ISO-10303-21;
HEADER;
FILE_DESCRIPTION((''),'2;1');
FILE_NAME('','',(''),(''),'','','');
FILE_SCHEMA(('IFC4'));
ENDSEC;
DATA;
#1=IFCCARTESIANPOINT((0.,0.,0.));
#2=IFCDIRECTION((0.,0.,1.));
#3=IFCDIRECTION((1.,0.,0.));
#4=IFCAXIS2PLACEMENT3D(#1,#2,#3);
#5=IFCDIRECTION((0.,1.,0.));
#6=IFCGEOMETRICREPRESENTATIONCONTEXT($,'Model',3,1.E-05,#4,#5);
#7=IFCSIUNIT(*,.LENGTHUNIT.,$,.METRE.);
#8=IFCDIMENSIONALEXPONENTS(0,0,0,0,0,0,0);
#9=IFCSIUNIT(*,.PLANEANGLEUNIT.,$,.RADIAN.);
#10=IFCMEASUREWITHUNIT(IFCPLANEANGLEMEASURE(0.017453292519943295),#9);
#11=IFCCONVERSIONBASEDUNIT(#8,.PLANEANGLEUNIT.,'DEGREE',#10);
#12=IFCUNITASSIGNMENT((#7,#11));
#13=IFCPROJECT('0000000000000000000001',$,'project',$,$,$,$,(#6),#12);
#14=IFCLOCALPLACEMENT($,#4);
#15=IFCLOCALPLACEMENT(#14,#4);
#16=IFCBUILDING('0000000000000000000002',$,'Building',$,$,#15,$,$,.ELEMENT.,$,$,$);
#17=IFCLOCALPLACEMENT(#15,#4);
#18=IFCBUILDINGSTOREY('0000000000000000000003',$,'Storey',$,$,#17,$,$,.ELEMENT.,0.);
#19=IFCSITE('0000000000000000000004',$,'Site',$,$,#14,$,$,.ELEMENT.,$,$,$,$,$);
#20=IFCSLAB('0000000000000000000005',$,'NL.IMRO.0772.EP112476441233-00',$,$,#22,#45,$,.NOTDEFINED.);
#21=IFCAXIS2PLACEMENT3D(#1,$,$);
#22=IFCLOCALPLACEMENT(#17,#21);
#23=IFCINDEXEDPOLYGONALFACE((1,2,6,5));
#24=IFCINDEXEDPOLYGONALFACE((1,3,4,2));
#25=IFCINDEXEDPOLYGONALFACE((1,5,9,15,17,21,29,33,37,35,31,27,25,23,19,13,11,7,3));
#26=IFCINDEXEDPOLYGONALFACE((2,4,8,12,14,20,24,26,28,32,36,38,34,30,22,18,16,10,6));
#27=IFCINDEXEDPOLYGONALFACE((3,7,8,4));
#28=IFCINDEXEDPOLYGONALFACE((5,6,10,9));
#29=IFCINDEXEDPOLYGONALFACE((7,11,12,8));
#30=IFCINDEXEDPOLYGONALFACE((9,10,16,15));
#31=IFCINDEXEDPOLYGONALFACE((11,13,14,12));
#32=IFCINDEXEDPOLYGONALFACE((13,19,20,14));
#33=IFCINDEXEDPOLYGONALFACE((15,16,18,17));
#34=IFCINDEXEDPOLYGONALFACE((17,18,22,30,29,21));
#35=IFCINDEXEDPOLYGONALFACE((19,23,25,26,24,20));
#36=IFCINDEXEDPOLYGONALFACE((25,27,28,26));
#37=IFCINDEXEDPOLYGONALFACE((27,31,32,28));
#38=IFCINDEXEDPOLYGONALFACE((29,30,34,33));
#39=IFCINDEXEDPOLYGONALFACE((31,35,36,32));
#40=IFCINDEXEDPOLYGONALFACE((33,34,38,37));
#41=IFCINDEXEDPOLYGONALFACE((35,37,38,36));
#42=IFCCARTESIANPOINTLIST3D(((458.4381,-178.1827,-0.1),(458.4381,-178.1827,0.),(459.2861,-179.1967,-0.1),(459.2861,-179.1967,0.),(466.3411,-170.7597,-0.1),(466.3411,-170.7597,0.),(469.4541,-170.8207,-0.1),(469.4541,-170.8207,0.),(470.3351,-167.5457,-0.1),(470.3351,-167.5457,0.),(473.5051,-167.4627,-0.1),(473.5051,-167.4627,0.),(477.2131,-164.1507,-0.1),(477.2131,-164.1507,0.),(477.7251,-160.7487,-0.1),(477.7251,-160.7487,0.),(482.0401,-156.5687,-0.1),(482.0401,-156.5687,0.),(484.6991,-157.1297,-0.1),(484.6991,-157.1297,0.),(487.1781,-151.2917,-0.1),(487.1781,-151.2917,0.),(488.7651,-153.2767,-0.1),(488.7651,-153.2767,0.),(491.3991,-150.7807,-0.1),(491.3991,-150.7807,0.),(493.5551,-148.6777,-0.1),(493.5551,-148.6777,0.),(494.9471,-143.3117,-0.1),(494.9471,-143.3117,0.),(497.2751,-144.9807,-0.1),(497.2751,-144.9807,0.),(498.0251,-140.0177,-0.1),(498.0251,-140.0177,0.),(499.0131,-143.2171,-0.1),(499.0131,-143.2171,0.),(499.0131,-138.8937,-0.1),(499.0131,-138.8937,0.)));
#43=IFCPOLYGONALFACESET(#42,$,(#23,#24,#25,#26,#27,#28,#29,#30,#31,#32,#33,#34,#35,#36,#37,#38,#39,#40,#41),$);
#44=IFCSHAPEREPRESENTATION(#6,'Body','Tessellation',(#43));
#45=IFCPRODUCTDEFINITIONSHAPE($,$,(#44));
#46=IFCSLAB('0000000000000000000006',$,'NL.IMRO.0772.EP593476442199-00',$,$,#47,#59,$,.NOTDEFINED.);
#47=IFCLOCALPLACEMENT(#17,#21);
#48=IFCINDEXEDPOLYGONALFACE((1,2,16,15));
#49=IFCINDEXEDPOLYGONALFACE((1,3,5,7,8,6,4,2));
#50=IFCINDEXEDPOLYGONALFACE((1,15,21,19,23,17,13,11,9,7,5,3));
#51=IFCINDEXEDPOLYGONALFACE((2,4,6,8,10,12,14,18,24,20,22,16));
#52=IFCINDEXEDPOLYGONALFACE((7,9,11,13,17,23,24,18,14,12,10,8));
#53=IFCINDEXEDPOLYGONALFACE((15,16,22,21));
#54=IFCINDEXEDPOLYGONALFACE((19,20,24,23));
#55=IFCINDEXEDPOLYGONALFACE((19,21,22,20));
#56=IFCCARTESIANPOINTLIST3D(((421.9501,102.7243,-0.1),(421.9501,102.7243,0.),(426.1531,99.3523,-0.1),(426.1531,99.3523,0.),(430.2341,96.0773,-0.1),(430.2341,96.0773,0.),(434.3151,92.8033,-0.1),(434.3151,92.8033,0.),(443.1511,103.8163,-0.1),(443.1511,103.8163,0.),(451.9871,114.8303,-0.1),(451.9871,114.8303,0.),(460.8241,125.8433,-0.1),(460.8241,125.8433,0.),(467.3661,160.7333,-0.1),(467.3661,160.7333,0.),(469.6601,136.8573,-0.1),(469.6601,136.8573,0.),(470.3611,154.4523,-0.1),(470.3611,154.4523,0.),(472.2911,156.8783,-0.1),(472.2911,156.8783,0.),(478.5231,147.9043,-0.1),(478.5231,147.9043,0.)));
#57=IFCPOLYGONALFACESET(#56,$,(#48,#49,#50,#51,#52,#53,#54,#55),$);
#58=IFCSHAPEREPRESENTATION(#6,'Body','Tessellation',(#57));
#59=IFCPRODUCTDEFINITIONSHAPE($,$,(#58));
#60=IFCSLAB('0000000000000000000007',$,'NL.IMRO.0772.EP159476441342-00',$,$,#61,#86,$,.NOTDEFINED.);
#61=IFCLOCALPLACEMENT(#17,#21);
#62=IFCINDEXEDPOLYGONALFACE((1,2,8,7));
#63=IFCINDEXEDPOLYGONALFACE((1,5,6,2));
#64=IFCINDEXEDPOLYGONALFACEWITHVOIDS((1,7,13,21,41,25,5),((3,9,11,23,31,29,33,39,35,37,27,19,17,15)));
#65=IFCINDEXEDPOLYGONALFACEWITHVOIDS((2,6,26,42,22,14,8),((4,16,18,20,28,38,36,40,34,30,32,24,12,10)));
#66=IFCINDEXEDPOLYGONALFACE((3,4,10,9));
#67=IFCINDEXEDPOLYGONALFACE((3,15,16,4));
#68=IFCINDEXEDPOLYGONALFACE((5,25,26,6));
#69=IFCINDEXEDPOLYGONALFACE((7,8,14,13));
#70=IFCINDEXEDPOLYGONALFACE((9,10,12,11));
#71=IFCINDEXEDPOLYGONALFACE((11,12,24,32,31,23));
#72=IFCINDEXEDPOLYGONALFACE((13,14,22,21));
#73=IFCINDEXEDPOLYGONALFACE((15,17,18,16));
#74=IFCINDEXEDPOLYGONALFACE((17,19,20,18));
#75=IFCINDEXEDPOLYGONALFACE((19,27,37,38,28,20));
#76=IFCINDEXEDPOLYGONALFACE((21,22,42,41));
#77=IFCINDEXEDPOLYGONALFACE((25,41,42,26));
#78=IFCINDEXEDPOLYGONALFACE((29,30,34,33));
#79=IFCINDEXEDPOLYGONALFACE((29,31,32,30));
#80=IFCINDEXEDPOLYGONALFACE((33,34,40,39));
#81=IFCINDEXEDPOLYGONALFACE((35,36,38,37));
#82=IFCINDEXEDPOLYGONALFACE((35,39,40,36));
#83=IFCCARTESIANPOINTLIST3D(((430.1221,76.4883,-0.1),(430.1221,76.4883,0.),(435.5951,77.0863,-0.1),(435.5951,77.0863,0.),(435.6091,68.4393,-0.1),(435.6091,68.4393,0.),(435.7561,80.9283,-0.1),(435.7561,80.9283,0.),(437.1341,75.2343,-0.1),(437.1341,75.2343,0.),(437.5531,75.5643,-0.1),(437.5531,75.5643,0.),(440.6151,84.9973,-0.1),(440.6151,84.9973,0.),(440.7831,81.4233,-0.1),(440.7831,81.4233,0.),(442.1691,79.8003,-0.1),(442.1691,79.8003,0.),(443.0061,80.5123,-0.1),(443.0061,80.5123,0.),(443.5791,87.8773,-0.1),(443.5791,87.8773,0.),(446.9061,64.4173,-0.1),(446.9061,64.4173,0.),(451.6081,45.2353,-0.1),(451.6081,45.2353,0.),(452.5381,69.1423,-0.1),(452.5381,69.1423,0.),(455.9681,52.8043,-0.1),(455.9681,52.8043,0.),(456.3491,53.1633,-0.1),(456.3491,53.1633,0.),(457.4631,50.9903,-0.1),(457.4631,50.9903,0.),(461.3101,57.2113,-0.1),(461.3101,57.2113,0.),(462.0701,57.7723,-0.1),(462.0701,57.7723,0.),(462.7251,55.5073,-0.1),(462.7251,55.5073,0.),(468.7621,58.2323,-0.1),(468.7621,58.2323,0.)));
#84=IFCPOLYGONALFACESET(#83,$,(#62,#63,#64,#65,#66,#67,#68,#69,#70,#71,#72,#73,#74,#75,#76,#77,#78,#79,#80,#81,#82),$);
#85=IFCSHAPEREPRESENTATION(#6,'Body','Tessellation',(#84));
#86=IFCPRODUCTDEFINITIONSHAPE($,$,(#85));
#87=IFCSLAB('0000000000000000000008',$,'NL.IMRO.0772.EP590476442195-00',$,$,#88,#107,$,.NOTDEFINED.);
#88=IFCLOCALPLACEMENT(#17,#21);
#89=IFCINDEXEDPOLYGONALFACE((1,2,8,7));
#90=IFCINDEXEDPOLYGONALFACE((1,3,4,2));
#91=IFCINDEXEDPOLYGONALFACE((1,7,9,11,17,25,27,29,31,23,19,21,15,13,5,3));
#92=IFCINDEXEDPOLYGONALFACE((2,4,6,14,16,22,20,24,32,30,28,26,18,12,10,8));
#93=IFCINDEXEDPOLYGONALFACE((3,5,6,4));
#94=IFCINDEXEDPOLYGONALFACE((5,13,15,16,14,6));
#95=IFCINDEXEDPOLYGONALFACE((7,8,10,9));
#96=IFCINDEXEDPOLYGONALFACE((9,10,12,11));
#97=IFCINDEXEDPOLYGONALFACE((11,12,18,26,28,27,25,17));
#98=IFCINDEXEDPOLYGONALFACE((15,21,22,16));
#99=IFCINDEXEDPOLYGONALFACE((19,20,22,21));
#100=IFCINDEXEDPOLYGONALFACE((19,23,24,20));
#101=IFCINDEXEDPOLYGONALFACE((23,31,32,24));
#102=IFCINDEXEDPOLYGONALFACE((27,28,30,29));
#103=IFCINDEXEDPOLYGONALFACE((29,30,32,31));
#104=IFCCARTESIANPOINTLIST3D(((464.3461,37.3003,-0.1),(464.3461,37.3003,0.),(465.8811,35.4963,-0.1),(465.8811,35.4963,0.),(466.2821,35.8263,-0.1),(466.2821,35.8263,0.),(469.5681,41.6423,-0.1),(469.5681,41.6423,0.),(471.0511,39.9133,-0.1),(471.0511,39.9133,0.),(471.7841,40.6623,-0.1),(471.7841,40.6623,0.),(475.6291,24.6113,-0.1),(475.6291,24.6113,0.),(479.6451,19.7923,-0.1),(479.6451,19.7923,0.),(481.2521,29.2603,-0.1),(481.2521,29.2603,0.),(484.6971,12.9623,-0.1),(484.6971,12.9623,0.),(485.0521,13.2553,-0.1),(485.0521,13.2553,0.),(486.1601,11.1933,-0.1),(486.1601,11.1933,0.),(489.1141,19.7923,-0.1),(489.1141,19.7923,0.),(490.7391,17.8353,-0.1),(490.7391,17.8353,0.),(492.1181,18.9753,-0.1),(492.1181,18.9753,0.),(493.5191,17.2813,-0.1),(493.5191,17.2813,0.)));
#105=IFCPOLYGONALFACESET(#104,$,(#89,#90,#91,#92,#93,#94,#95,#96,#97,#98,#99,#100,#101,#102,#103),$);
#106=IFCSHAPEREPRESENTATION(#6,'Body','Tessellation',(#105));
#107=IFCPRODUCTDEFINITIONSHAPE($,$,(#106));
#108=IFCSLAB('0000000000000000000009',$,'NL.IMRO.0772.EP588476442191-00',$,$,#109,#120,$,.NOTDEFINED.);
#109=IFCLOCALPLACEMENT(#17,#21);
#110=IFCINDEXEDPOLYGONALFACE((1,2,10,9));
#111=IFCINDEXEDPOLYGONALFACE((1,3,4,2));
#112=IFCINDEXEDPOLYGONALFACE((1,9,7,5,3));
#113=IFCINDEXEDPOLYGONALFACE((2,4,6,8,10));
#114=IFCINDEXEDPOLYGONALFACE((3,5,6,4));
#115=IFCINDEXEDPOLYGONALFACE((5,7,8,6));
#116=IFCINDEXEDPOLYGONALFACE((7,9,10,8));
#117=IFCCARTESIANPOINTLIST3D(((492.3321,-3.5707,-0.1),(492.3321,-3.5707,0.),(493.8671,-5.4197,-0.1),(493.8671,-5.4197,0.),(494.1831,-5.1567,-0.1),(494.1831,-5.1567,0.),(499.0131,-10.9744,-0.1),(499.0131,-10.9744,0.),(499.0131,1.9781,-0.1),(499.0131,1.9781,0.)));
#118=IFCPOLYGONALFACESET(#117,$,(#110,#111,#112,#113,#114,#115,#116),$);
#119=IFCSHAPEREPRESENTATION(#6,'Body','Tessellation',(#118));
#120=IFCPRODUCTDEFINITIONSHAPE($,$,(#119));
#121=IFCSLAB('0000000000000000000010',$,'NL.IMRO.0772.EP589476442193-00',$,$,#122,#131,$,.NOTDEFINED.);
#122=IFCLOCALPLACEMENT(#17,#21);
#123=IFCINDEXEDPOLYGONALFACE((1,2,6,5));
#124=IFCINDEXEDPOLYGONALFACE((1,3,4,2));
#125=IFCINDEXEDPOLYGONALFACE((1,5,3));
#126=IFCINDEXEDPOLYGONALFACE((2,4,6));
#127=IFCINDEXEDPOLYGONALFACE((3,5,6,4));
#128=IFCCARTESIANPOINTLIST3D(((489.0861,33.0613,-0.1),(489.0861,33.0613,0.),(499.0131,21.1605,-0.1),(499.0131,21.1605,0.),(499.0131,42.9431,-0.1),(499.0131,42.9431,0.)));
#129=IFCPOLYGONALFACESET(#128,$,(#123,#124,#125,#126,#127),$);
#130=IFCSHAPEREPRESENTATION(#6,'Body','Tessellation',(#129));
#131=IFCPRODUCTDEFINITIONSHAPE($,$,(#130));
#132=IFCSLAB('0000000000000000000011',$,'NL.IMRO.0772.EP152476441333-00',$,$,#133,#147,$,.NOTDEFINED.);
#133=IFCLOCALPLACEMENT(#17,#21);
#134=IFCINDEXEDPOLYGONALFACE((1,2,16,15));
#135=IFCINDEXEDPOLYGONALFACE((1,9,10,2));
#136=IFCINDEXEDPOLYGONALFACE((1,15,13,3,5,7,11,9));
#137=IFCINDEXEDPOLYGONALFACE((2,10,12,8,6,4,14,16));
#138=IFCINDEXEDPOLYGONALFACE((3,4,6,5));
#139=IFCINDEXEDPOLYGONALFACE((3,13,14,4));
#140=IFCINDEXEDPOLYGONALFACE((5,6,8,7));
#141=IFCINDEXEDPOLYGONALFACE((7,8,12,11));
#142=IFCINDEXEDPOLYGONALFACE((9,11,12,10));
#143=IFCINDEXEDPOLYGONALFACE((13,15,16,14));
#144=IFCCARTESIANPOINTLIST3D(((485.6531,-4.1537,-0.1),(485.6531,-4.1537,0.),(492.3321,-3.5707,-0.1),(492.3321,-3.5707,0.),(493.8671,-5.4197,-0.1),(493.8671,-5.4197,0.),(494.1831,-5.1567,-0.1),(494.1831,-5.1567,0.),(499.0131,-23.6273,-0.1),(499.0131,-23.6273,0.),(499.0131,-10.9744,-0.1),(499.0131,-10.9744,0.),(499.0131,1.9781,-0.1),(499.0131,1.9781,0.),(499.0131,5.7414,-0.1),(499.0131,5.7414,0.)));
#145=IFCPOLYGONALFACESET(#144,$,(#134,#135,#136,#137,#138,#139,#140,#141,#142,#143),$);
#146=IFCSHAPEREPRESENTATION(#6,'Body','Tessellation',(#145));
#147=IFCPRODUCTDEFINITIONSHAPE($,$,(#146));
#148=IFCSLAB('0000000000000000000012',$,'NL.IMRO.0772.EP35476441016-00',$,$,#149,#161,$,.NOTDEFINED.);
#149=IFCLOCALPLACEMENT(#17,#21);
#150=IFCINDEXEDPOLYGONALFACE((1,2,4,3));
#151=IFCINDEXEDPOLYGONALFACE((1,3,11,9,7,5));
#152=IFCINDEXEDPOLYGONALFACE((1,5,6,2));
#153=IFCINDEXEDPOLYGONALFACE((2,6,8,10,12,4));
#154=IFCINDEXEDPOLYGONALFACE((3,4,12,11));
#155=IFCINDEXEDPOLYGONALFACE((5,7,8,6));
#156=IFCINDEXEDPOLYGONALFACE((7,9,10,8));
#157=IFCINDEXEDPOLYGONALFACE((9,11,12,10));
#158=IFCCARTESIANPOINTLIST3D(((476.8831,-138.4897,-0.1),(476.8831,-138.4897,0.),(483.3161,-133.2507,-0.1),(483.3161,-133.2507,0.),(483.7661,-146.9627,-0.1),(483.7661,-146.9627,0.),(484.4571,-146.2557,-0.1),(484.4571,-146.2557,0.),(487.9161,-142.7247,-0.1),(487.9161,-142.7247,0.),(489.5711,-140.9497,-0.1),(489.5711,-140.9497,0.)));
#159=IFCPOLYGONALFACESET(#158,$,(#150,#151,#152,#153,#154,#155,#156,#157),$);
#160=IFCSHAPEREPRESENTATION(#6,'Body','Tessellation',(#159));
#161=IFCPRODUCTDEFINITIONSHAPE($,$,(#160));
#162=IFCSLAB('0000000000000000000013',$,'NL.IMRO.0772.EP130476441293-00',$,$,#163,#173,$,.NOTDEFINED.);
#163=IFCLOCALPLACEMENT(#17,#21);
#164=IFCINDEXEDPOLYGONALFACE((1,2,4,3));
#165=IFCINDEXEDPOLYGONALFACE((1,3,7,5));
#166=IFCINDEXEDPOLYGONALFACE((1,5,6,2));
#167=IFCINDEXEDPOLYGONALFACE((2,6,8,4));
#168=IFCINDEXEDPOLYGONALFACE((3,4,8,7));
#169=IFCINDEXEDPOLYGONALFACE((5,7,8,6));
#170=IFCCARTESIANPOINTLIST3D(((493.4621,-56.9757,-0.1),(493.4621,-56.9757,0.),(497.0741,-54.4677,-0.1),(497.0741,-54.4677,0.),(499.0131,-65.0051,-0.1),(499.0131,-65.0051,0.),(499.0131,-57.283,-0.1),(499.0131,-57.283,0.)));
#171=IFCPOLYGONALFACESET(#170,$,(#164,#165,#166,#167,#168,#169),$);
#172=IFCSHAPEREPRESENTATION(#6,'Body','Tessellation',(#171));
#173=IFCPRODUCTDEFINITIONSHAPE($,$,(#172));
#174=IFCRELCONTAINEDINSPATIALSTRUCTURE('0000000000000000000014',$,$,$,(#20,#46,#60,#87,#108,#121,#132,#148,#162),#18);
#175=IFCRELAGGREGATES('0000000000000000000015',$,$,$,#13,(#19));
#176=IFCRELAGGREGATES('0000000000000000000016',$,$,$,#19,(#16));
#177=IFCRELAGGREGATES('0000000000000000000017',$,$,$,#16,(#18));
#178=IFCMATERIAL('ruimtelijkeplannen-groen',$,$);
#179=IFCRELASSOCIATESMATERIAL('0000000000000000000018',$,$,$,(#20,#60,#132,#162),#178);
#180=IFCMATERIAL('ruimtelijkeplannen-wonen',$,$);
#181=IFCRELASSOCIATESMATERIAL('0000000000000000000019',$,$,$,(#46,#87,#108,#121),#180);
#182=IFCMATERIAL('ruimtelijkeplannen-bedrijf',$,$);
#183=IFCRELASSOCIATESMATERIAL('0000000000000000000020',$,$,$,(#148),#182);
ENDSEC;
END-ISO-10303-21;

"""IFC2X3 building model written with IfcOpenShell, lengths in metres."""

from ifc_helpers import new_model, entity, si_unit, converted_unit, direction, frame, origin_with_axes, place, context, project, spatial, polyline, outline, extrude, material, element, save


model = new_model("IFC2X3")

# Units and contexts
model_context = context("Model", 3, precision=1e-05, world=origin_with_axes(), true_north=direction((0.0, 1.0, 0.0)))
ifc_project = project(units=[si_unit("LENGTHUNIT", "METRE"), converted_unit("PLANEANGLEUNIT", "DEGREE", entity("IfcPlaneAngleMeasure", 0.017453292519943295), si_unit("PLANEANGLEUNIT", "RADIAN"), dimensions=[0, 0, 0, 0, 0, 0, 0])], contexts=[model_context])

# Site, building, storey
site_placement = place(None, origin_with_axes())
site = spatial("IfcSite", under=ifc_project, at=site_placement, Name="Site", CompositionType="ELEMENT")
building_placement = place(site_placement, origin_with_axes())
building = spatial("IfcBuilding", under=site, at=building_placement, Name="Building", CompositionType="ELEMENT")
storey_placement = place(building_placement, origin_with_axes())
storey = spatial("IfcBuildingStorey", under=building, at=storey_placement, Name="Storey", CompositionType="ELEMENT", Elevation=0.0)

# Slabs
ifc_material_1 = material(Name="ruimtelijkeplannen-groen")
slab_1_placement = place(storey_placement, frame((0.0, 0.0, -0.1), z_axis=(0.0, 0.0, 1.0), x_axis=(1.0, 0.0, 0.0)))
element("IfcSlab", 1, at=slab_1_placement, inside=storey, material=ifc_material_1, Name="NL.IMRO.0772.EP112476441233-00", PredefinedType="NOTDEFINED", context=model_context, shape_type="SweptSolid", body=[
    extrude(outline(polyline([(497.2751, -144.9807), (493.5551, -148.6777), (491.3991, -150.7807), (488.7651, -153.2767), (484.6991, -157.1297), (477.2131, -164.1507), (473.5051, -167.4627), (469.4541, -170.8207), (459.2861, -179.1967), (458.4381, -178.1827), (466.3411, -170.7597), (470.3351, -167.5457), (477.7251, -160.7487), (482.0401, -156.5687), (487.1781, -151.2917), (494.9471, -143.3117), (498.0251, -140.0177), (499.0131, -138.8937), (499.0131, -143.2171), (497.2751, -144.9807)])), origin_with_axes(), (0.0, 0.0, 1.0), 0.1),
])
ifc_material_2 = material(Name="ruimtelijkeplannen-wonen")
slab_2_placement = place(storey_placement, frame((0.0, 0.0, -0.1), z_axis=(0.0, 0.0, 1.0), x_axis=(1.0, 0.0, 0.0)))
element("IfcSlab", 2, at=slab_2_placement, inside=storey, material=ifc_material_2, Name="NL.IMRO.0772.EP593476442199-00", PredefinedType="NOTDEFINED", context=model_context, shape_type="SweptSolid", body=[
    extrude(outline(polyline([(467.3661, 160.7333), (472.2911, 156.8783), (470.3611, 154.4523), (478.5231, 147.9043), (469.6601, 136.8573), (460.8241, 125.8433), (451.9871, 114.8303), (443.1511, 103.8163), (434.3151, 92.8033), (430.2341, 96.0773), (426.1531, 99.3523), (421.9501, 102.7243), (467.3661, 160.7333)])), origin_with_axes(), (0.0, 0.0, 1.0), 0.1),
])
slab_3_placement = place(storey_placement, frame((0.0, 0.0, -0.1), z_axis=(0.0, 0.0, 1.0), x_axis=(1.0, 0.0, 0.0)))
element("IfcSlab", 3, at=slab_3_placement, inside=storey, material=ifc_material_1, Name="NL.IMRO.0772.EP159476441342-00", PredefinedType="NOTDEFINED", context=model_context, shape_type="SweptSolid", body=[
    extrude(outline(polyline([(430.1221, 76.4883), (435.7561, 80.9283), (440.6151, 84.9973), (443.5791, 87.8773), (468.7621, 58.2323), (451.6081, 45.2353), (435.6091, 68.4393), (430.1221, 76.4883)]), holes=[polyline([(443.0061, 80.5123), (442.1691, 79.8003), (440.7831, 81.4233), (435.5951, 77.0863), (437.1341, 75.2343), (437.5531, 75.5643), (446.9061, 64.4173), (456.3491, 53.1633), (455.9681, 52.8043), (457.4631, 50.9903), (462.7251, 55.5073), (461.3101, 57.2113), (462.0701, 57.7723), (452.5381, 69.1423), (443.0061, 80.5123)])]), origin_with_axes(), (0.0, 0.0, 1.0), 0.1),
])
slab_4_placement = place(storey_placement, frame((0.0, 0.0, -0.1), z_axis=(0.0, 0.0, 1.0), x_axis=(1.0, 0.0, 0.0)))
element("IfcSlab", 4, at=slab_4_placement, inside=storey, material=ifc_material_2, Name="NL.IMRO.0772.EP590476442195-00", PredefinedType="NOTDEFINED", context=model_context, shape_type="SweptSolid", body=[
    extrude(outline(polyline([(481.2521, 29.2603), (489.1141, 19.7923), (490.7391, 17.8353), (492.1181, 18.9753), (493.5191, 17.2813), (486.1601, 11.1933), (484.6971, 12.9623), (485.0521, 13.2553), (479.6451, 19.7923), (475.6291, 24.6113), (466.2821, 35.8263), (465.8811, 35.4963), (464.3461, 37.3003), (469.5681, 41.6423), (471.0511, 39.9133), (471.7841, 40.6623), (481.2521, 29.2603)])), origin_with_axes(), (0.0, 0.0, 1.0), 0.1),
])
slab_5_placement = place(storey_placement, frame((0.0, 0.0, -0.1), z_axis=(0.0, 0.0, 1.0), x_axis=(1.0, 0.0, 0.0)))
element("IfcSlab", 5, at=slab_5_placement, inside=storey, material=ifc_material_2, Name="NL.IMRO.0772.EP588476442191-00", PredefinedType="NOTDEFINED", context=model_context, shape_type="SweptSolid", body=[
    extrude(outline(polyline([(494.1831, -5.1567), (493.8671, -5.4197), (492.3321, -3.5707), (499.0131, 1.9781), (499.0131, -10.9744), (494.1831, -5.1567)])), origin_with_axes(), (0.0, 0.0, 1.0), 0.1),
])
slab_6_placement = place(storey_placement, frame((0.0, 0.0, -0.1), z_axis=(0.0, 0.0, 1.0), x_axis=(1.0, 0.0, 0.0)))
element("IfcSlab", 6, at=slab_6_placement, inside=storey, material=ifc_material_2, Name="NL.IMRO.0772.EP589476442193-00", PredefinedType="NOTDEFINED", context=model_context, shape_type="SweptSolid", body=[
    extrude(outline(polyline([(489.0861, 33.0613), (499.0131, 42.9431), (499.0131, 21.1605), (489.0861, 33.0613)])), origin_with_axes(), (0.0, 0.0, 1.0), 0.1),
])
slab_7_placement = place(storey_placement, frame((0.0, 0.0, -0.1), z_axis=(0.0, 0.0, 1.0), x_axis=(1.0, 0.0, 0.0)))
element("IfcSlab", 7, at=slab_7_placement, inside=storey, material=ifc_material_1, Name="NL.IMRO.0772.EP152476441333-00", PredefinedType="NOTDEFINED", context=model_context, shape_type="SweptSolid", body=[
    extrude(outline(polyline([(485.6531, -4.1537), (499.0131, 5.7414), (499.0131, 1.9781), (492.3321, -3.5707), (493.8671, -5.4197), (494.1831, -5.1567), (499.0131, -10.9744), (499.0131, -23.6273), (485.6531, -4.1537)])), origin_with_axes(), (0.0, 0.0, 1.0), 0.1),
])
ifc_material_3 = material(Name="ruimtelijkeplannen-bedrijf")
slab_8_placement = place(storey_placement, frame((0.0, 0.0, -0.1), z_axis=(0.0, 0.0, 1.0), x_axis=(1.0, 0.0, 0.0)))
element("IfcSlab", 8, at=slab_8_placement, inside=storey, material=ifc_material_3, Name="NL.IMRO.0772.EP35476441016-00", PredefinedType="NOTDEFINED", context=model_context, shape_type="SweptSolid", body=[
    extrude(outline(polyline([(483.7661, -146.9627), (476.8831, -138.4897), (483.3161, -133.2507), (489.5711, -140.9497), (487.9161, -142.7247), (484.4571, -146.2557), (483.7661, -146.9627)])), origin_with_axes(), (0.0, 0.0, 1.0), 0.1),
])
slab_9_placement = place(storey_placement, frame((0.0, 0.0, -0.1), z_axis=(0.0, 0.0, 1.0), x_axis=(1.0, 0.0, 0.0)))
element("IfcSlab", 9, at=slab_9_placement, inside=storey, material=ifc_material_1, Name="NL.IMRO.0772.EP130476441293-00", PredefinedType="NOTDEFINED", context=model_context, shape_type="SweptSolid", body=[
    extrude(outline(polyline([(493.4621, -56.9757), (497.0741, -54.4677), (499.0131, -57.283), (499.0131, -65.0051), (493.4621, -56.9757)])), origin_with_axes(), (0.0, 0.0, 1.0), 0.1),
])

save(model, "model.ifc")
